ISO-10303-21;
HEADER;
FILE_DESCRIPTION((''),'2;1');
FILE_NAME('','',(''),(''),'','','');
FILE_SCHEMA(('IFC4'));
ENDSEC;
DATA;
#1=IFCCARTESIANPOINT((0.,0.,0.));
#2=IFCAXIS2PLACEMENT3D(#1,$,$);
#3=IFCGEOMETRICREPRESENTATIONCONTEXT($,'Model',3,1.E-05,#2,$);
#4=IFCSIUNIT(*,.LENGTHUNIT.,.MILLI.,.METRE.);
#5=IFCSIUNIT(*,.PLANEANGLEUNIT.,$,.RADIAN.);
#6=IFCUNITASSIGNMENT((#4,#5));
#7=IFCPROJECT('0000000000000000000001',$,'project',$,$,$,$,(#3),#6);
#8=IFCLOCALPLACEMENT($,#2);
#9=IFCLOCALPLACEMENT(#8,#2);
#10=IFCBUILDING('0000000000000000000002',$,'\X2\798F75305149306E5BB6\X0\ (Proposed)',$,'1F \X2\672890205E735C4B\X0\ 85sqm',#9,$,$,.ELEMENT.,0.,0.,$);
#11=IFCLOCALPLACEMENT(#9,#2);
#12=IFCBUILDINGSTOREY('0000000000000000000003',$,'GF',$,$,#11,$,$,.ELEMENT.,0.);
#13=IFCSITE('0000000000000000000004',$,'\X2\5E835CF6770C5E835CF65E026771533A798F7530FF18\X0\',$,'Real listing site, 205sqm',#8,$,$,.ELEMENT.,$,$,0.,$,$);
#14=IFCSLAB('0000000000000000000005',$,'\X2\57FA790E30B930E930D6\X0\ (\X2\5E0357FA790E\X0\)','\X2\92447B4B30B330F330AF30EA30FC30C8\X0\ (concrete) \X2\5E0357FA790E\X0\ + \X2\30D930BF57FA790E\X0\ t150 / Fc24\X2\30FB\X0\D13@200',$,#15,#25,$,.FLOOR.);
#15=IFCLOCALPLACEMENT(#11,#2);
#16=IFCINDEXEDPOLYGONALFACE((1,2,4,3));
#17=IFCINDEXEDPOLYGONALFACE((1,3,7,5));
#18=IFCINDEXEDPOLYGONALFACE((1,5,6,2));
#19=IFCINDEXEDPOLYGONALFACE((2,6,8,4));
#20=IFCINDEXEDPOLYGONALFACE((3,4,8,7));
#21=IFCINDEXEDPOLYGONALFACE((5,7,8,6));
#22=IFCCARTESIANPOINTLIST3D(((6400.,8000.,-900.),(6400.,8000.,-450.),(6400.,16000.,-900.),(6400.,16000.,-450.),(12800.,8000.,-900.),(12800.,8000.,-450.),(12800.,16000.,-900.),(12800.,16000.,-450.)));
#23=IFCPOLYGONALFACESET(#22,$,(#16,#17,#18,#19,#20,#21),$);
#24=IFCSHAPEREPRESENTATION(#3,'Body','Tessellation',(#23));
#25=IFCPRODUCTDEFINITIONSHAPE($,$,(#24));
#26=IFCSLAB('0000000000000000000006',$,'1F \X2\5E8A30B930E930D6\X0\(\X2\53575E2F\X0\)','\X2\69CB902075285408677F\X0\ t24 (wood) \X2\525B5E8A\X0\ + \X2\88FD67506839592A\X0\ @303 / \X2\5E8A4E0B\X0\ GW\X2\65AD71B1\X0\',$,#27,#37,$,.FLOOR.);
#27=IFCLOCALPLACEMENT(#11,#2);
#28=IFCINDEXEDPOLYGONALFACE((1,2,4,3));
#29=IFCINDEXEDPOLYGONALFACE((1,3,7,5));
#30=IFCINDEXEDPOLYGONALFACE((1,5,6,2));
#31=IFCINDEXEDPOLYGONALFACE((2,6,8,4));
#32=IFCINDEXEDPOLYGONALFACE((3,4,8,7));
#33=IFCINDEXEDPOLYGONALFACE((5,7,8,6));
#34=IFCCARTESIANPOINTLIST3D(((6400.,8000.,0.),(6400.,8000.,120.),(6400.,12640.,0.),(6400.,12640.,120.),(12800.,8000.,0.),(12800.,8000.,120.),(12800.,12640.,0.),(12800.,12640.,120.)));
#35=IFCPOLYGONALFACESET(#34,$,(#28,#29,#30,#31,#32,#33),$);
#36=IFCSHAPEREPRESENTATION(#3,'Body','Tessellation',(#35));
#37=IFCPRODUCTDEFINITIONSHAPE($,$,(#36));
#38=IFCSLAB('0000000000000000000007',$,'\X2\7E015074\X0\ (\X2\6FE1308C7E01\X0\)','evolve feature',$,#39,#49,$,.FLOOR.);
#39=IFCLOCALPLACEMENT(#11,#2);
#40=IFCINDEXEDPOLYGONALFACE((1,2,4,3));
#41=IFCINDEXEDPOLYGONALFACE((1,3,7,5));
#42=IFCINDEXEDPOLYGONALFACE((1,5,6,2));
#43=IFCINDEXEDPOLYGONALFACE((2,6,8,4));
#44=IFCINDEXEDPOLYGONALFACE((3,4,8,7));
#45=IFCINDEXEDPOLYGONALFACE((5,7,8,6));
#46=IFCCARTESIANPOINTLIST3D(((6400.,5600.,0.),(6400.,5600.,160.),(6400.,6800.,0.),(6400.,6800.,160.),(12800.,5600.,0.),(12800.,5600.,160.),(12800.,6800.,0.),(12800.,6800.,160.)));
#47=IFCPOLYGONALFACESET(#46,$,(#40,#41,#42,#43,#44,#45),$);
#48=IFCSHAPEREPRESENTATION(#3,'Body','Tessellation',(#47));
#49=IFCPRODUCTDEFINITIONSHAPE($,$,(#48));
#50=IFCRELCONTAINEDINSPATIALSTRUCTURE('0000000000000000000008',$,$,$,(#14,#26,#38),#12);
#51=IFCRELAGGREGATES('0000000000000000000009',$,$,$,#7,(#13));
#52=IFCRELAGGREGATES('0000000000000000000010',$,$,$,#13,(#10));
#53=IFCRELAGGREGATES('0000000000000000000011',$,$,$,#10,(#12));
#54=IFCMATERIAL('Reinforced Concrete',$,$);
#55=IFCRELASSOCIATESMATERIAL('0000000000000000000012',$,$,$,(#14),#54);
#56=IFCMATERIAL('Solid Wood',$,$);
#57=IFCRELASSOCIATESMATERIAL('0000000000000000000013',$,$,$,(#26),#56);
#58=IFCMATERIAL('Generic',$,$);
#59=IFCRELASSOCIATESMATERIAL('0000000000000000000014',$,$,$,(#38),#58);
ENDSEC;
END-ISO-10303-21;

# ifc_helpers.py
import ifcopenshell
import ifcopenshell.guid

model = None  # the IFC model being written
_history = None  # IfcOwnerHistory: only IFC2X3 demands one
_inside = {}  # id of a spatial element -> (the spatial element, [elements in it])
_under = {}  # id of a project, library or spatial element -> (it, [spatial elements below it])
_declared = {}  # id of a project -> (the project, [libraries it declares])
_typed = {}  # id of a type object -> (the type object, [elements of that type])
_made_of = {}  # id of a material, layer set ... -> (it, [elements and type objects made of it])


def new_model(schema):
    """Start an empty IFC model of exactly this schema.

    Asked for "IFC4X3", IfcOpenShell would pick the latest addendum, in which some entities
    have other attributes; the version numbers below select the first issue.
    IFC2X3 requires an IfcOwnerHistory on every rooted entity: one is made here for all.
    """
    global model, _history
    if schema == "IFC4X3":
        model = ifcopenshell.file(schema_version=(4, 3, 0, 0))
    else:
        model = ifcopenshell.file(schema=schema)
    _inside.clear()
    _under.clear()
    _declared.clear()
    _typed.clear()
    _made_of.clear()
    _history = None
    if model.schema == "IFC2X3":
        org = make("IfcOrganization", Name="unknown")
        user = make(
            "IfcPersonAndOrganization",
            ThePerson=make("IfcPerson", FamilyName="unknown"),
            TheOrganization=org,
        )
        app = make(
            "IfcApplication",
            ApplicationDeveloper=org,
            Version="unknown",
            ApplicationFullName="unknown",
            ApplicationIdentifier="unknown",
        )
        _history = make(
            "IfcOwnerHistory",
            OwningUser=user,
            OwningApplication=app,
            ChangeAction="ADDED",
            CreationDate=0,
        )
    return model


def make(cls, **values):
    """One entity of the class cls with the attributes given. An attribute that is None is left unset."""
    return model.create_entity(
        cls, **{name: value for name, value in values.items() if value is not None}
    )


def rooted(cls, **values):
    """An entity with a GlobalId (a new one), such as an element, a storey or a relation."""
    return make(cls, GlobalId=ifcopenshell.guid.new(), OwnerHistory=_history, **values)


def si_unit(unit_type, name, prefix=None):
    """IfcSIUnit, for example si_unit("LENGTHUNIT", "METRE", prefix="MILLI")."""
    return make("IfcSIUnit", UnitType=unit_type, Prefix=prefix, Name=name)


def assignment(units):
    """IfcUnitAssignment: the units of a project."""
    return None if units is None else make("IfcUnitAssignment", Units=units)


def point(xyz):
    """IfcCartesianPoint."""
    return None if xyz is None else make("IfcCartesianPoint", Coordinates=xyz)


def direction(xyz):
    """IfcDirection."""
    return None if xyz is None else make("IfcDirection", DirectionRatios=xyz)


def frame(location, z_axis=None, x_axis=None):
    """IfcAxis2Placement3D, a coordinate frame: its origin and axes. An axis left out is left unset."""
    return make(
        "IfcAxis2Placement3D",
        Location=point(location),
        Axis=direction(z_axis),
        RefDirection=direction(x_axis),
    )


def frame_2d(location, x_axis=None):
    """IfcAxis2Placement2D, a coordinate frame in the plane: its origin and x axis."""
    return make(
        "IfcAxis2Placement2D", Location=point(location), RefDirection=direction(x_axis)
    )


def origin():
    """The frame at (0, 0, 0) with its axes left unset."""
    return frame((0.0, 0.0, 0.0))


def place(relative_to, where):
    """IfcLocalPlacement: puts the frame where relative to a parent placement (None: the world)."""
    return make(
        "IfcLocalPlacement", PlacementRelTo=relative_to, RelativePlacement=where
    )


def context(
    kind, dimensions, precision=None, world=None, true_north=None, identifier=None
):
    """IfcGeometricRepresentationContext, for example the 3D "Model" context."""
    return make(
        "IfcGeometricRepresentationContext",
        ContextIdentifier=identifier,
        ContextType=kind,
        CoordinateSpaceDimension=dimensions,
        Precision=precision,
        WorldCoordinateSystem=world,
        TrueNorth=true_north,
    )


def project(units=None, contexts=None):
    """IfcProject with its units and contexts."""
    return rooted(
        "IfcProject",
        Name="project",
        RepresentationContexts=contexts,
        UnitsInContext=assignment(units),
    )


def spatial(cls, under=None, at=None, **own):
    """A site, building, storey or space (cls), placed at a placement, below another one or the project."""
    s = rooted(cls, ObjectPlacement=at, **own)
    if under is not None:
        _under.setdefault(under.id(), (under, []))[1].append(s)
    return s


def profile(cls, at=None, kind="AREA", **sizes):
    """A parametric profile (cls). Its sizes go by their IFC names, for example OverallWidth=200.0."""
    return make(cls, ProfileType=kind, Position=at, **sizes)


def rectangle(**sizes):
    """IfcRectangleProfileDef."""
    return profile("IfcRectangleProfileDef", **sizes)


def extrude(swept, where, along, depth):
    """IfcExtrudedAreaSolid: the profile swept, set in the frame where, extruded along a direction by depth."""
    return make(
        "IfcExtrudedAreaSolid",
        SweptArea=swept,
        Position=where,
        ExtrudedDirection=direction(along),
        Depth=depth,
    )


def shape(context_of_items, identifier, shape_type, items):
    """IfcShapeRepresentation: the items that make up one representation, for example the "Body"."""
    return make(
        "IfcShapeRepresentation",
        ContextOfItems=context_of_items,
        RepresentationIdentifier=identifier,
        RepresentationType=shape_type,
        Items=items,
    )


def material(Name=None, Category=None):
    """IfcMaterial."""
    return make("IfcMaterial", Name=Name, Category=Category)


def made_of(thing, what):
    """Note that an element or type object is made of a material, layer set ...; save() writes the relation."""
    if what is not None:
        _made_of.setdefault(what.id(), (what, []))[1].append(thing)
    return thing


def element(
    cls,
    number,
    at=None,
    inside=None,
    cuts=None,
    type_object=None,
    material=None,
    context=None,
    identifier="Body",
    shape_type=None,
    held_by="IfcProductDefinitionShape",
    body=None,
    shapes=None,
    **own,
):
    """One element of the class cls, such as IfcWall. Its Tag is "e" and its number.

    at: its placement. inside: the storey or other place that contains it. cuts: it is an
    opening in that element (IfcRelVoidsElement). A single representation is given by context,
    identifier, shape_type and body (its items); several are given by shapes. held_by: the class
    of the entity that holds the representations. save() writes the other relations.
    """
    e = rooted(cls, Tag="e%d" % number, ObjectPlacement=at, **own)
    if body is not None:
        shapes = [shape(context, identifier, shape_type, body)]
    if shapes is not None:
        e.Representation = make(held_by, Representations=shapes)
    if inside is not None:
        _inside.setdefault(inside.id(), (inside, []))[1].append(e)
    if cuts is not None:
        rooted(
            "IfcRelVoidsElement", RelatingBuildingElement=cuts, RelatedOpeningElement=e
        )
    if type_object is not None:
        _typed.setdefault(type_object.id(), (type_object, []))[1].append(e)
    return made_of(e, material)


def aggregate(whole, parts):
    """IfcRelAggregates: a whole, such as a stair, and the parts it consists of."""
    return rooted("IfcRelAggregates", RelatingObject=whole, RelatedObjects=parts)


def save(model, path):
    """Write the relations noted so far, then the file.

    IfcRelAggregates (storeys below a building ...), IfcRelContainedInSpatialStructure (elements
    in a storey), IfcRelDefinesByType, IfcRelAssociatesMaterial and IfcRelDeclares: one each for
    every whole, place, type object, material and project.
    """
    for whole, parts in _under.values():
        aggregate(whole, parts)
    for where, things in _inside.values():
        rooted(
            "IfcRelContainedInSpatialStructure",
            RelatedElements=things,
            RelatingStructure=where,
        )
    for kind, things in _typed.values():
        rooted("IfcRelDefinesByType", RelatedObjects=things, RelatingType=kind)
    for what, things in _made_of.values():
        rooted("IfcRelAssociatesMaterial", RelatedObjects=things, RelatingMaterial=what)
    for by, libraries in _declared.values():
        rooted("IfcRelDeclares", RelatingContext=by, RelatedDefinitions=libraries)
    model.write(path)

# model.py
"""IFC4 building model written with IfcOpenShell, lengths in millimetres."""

from ifc_helpers import new_model, si_unit, frame, frame_2d, origin, place, context, project, spatial, rectangle, extrude, material, element, save


model = new_model("IFC4")

# Units and contexts
model_context = context("Model", 3, precision=1e-05, world=origin())
ifc_project = project(units=[si_unit("LENGTHUNIT", "METRE", prefix="MILLI"), si_unit("PLANEANGLEUNIT", "RADIAN")], contexts=[model_context])

# Site, building, storey
site_placement = place(None, origin())
site = spatial("IfcSite", under=ifc_project, at=site_placement, Name="広島県広島市東区福田８", ObjectType="Real listing site, 205sqm", CompositionType="ELEMENT", RefElevation=0.0)
building_placement = place(site_placement, origin())
building = spatial("IfcBuilding", under=site, at=building_placement, Name="福田光の家 (Proposed)", ObjectType="1F 木造平屋 85sqm", CompositionType="ELEMENT", ElevationOfRefHeight=0.0, ElevationOfTerrain=0.0)
storey_placement = place(building_placement, origin())
storey = spatial("IfcBuildingStorey", under=building, at=storey_placement, Name="GF", CompositionType="ELEMENT", Elevation=0.0)

# Slabs
ifc_material_1 = material(Name="Reinforced Concrete")
slab_1_placement = place(storey_placement, frame((3200.0, 4000.0, -450.0)))
element("IfcSlab", 1, at=slab_1_placement, inside=storey, material=ifc_material_1, Name="基礎スラブ (布基礎)", Description="鉄筋コンクリート (concrete) 布基礎 + ベタ基礎 t150 / Fc24・D13@200", PredefinedType="FLOOR", context=model_context, shape_type="SweptSolid", body=[
    extrude(rectangle(XDim=6400.0, YDim=8000.0, at=frame_2d((3200.0, 4000.0))), frame((3200.0, 4000.0, -450.0)), (0.0, 0.0, 1.0), 450.0),
])
ifc_material_2 = material(Name="Solid Wood")
slab_2_placement = place(storey_placement, frame((3200.0, 4000.0, 0.0)))
element("IfcSlab", 2, at=slab_2_placement, inside=storey, material=ifc_material_2, Name="1F 床スラブ(南帯)", Description="構造用合板 t24 (wood) 剛床 + 製材根太 @303 / 床下 GW断熱", PredefinedType="FLOOR", context=model_context, shape_type="SweptSolid", body=[
    extrude(rectangle(XDim=6400.0, YDim=4640.0, at=frame_2d((3200.0, 2320.0))), frame((3200.0, 4000.0, 0.0)), (0.0, 0.0, 1.0), 120.0),
])
ifc_material_3 = material(Name="Generic")
slab_3_placement = place(storey_placement, frame((3200.0, 2800.0, 0.0)))
element("IfcSlab", 3, at=slab_3_placement, inside=storey, material=ifc_material_3, Name="縁側 (濡れ縁)", Description="evolve feature", PredefinedType="FLOOR", context=model_context, shape_type="SweptSolid", body=[
    extrude(rectangle(XDim=6400.0, YDim=1200.0, at=frame_2d((3200.0, 600.0))), frame((3200.0, 2800.0, 0.0)), (0.0, 0.0, 1.0), 160.0),
])

save(model, "model.ifc")
